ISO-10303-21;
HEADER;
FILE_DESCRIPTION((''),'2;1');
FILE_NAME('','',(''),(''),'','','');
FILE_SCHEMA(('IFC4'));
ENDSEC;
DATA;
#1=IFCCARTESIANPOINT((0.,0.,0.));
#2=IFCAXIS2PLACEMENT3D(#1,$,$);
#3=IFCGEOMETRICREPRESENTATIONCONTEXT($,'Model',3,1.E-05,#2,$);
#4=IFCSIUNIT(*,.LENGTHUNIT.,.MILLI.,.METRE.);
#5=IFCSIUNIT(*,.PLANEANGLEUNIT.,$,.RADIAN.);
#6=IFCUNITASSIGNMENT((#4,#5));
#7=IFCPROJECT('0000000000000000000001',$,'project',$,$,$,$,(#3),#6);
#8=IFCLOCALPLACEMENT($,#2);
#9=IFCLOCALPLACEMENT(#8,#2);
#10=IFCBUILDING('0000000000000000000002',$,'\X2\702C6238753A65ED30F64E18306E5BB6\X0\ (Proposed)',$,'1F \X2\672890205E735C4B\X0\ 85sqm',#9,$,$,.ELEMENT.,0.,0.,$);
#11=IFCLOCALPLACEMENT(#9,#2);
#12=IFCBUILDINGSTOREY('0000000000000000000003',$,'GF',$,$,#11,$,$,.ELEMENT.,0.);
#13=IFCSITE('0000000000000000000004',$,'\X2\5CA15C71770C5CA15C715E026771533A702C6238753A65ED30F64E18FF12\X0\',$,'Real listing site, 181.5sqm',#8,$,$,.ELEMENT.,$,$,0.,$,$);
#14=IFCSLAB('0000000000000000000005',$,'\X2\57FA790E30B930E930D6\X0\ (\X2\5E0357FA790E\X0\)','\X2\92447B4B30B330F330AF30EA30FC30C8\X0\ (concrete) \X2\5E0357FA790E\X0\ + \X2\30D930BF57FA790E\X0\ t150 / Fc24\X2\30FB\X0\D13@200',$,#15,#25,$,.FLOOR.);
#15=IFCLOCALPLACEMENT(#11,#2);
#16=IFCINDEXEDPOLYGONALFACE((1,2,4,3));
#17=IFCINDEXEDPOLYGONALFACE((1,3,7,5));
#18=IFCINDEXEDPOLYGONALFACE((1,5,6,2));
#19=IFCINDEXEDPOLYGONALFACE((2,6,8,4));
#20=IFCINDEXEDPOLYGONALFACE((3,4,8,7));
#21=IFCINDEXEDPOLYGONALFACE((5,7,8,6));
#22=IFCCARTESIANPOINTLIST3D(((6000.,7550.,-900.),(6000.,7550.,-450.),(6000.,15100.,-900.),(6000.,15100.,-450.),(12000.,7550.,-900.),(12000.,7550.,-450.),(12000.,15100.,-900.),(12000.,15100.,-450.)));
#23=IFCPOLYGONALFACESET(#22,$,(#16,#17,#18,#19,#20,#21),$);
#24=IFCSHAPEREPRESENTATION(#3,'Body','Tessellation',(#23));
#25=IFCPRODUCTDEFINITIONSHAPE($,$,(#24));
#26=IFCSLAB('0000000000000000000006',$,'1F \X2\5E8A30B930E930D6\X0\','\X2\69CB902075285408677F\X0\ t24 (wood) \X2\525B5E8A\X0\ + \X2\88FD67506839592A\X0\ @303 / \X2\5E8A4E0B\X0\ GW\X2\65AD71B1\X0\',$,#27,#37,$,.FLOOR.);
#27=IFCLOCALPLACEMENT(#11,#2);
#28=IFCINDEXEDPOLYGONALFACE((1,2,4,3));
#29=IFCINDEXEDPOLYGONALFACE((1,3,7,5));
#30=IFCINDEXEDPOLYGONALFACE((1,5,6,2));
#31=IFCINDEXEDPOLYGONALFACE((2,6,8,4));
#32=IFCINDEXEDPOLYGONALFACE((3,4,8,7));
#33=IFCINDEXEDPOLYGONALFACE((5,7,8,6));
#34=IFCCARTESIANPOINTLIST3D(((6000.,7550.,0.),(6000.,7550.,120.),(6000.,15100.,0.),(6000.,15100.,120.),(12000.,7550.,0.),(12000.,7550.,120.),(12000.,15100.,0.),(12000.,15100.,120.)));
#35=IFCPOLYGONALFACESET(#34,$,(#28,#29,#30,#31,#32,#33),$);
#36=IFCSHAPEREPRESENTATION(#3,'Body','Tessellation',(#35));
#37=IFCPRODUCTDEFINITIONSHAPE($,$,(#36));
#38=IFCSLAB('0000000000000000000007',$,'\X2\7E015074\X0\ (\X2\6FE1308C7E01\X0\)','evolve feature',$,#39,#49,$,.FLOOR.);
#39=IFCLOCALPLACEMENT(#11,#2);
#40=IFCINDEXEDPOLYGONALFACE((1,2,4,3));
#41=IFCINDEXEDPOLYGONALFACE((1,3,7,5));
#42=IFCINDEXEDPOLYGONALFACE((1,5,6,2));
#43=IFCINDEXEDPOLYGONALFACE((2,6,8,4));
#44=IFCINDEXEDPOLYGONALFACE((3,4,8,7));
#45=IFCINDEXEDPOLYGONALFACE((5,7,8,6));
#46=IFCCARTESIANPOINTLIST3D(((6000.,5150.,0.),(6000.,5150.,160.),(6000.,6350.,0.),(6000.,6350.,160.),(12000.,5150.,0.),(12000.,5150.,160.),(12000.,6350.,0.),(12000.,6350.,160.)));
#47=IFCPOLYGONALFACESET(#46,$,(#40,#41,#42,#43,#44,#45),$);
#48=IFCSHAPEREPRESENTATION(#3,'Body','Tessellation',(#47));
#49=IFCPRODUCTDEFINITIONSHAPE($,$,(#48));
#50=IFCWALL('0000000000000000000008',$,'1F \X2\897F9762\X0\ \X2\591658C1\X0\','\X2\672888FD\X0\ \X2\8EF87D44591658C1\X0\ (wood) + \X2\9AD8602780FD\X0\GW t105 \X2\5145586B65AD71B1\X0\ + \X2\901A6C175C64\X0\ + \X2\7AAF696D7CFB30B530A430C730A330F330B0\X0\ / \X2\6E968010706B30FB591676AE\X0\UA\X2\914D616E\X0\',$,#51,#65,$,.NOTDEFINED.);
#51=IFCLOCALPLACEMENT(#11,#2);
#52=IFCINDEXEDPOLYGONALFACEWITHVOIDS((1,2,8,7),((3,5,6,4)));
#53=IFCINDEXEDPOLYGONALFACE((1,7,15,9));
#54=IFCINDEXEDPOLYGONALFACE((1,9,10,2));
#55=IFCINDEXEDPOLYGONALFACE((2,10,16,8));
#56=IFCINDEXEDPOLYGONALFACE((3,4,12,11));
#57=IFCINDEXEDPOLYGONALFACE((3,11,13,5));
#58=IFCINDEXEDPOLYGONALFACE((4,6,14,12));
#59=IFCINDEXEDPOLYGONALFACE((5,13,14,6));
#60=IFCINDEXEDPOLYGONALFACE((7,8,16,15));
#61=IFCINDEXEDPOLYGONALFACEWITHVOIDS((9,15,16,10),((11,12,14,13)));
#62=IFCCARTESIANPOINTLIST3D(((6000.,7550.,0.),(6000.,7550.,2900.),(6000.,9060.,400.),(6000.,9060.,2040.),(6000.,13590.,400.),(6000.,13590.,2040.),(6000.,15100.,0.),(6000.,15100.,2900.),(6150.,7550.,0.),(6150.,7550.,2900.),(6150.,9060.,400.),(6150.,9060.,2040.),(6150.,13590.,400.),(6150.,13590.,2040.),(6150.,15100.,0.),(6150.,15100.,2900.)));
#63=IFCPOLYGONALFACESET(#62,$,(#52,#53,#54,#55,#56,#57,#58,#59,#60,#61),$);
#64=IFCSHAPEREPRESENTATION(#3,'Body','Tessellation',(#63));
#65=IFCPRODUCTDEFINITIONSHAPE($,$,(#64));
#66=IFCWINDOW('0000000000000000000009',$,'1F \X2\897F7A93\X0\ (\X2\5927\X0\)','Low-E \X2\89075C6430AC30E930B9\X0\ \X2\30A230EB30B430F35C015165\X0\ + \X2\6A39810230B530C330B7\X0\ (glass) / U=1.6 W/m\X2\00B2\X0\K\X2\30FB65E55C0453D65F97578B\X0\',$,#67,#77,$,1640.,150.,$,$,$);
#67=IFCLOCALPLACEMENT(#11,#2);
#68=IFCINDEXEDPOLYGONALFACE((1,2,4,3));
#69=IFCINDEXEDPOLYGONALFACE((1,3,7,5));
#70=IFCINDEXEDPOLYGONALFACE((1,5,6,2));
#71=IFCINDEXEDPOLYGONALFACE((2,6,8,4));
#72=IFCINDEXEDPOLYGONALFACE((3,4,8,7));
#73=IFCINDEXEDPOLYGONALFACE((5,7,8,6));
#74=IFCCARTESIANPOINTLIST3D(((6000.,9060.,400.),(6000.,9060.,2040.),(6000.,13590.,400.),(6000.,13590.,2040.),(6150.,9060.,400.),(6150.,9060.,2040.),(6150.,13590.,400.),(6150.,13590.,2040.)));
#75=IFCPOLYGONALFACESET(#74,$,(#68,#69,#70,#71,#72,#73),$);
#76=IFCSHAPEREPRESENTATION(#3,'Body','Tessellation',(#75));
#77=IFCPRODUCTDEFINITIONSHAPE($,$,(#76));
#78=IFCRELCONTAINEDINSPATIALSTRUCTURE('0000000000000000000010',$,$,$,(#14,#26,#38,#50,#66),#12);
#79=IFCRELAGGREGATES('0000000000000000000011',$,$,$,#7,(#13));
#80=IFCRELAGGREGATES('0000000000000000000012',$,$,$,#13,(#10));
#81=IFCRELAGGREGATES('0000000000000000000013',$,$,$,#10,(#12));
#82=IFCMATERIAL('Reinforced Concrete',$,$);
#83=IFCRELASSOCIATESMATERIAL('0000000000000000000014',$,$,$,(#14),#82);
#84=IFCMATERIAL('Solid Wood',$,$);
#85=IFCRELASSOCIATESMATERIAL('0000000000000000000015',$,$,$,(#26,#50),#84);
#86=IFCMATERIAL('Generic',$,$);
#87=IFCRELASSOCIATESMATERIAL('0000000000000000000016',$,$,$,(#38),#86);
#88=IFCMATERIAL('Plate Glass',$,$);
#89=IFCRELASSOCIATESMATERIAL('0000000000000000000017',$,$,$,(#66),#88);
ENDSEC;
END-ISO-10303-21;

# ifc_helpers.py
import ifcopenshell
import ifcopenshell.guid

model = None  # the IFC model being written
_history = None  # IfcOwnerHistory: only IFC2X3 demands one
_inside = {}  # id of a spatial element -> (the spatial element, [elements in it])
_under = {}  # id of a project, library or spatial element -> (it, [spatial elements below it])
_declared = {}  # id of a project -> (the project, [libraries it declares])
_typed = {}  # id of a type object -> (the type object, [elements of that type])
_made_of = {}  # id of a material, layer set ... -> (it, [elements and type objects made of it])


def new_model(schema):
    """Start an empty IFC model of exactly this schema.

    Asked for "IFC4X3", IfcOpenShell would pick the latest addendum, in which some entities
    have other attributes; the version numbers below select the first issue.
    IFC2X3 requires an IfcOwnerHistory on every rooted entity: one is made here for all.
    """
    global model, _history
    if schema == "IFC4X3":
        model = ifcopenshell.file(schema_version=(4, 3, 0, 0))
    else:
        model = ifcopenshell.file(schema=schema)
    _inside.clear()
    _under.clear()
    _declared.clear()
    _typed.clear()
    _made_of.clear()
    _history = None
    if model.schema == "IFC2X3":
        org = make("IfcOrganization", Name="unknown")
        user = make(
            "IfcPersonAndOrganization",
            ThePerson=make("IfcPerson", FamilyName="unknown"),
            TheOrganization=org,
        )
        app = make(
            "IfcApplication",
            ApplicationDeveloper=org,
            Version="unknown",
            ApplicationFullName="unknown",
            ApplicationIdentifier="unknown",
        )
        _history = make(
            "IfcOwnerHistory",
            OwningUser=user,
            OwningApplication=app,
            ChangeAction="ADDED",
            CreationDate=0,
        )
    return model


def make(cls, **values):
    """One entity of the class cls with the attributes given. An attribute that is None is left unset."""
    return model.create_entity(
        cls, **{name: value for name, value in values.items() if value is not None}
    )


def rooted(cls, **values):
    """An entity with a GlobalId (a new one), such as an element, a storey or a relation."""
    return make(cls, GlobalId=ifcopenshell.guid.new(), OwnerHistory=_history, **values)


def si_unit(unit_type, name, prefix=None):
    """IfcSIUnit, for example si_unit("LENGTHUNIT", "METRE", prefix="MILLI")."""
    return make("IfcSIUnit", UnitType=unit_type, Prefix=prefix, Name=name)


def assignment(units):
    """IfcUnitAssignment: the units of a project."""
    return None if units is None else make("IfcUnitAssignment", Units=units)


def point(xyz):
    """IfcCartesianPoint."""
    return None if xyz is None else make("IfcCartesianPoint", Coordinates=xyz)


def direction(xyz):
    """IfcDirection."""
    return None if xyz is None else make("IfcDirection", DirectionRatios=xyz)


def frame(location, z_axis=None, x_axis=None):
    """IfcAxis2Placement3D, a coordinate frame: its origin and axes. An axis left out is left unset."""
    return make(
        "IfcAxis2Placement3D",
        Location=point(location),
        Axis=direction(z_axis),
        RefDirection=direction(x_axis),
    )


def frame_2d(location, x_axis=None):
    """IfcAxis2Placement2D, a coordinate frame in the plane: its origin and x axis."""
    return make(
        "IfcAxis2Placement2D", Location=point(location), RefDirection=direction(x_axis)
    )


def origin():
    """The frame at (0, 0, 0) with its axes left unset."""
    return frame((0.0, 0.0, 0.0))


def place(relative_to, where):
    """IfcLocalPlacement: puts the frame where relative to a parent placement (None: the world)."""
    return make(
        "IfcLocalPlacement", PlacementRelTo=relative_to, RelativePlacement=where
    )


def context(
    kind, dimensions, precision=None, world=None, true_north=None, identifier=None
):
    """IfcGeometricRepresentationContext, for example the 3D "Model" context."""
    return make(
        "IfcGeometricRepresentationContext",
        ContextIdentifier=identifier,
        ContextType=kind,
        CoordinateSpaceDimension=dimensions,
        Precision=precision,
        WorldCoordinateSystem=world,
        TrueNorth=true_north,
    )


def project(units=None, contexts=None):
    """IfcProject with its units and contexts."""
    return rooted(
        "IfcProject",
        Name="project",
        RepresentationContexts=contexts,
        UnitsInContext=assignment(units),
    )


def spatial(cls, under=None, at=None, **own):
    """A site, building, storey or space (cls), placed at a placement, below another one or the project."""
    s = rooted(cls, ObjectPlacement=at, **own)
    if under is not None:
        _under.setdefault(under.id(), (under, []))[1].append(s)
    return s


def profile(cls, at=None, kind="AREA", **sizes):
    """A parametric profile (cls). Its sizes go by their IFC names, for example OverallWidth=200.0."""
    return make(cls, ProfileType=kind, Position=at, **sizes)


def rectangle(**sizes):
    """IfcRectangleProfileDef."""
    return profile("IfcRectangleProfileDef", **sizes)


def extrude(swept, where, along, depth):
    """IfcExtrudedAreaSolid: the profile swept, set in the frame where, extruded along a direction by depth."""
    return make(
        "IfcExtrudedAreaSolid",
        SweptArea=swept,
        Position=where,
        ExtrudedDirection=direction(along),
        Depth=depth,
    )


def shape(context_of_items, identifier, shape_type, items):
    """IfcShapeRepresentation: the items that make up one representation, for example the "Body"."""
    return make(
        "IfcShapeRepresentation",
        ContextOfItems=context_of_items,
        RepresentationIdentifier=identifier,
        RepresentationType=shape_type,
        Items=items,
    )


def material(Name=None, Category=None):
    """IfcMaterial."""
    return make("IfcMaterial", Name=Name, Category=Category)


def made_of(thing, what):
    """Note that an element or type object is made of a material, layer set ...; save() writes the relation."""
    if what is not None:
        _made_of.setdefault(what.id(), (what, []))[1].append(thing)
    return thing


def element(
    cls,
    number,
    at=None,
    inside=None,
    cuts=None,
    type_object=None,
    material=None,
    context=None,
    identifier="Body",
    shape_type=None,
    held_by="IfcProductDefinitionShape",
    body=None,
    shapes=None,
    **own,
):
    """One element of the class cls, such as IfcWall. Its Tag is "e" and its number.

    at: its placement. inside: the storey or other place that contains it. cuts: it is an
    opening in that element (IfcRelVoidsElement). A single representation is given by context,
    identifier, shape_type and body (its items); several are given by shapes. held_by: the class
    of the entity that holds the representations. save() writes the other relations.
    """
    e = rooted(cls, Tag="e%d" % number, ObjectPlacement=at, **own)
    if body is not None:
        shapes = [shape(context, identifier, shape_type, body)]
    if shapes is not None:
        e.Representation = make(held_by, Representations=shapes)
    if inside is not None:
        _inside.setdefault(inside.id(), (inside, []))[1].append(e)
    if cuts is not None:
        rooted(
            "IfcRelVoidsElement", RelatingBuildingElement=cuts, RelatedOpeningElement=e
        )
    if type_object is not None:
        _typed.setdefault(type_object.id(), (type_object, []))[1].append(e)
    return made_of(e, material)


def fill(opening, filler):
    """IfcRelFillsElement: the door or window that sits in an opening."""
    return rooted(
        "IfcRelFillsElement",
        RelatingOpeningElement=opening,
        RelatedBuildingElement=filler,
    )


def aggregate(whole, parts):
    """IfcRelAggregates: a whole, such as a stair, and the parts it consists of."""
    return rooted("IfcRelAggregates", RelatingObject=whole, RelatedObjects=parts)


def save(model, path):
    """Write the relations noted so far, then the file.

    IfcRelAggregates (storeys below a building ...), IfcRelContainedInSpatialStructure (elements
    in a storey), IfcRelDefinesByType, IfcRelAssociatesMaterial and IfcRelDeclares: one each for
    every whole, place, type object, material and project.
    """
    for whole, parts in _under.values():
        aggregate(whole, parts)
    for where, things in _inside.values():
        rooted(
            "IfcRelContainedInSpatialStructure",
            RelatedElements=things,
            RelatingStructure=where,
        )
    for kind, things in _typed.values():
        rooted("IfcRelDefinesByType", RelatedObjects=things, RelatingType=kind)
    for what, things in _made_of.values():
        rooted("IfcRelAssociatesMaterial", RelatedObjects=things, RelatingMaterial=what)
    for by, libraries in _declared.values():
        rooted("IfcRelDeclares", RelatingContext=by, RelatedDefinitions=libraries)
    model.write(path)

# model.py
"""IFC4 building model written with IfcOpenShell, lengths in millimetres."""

from ifc_helpers import new_model, si_unit, frame, frame_2d, origin, place, context, project, spatial, rectangle, extrude, material, element, fill, save


model = new_model("IFC4")

# Units and contexts
model_context = context("Model", 3, precision=1e-05, world=origin())
ifc_project = project(units=[si_unit("LENGTHUNIT", "METRE", prefix="MILLI"), si_unit("PLANEANGLEUNIT", "RADIAN")], contexts=[model_context])

# Site, building, storey
site_placement = place(None, origin())
site = spatial("IfcSite", under=ifc_project, at=site_placement, Name="岡山県岡山市東区瀬戸町旭ヶ丘２", ObjectType="Real listing site, 181.5sqm", CompositionType="ELEMENT", RefElevation=0.0)
building_placement = place(site_placement, origin())
building = spatial("IfcBuilding", under=site, at=building_placement, Name="瀬戸町旭ヶ丘の家 (Proposed)", ObjectType="1F 木造平屋 85sqm", CompositionType="ELEMENT", ElevationOfRefHeight=0.0, ElevationOfTerrain=0.0)
storey_placement = place(building_placement, origin())
storey = spatial("IfcBuildingStorey", under=building, at=storey_placement, Name="GF", CompositionType="ELEMENT", Elevation=0.0)

# Slabs
ifc_material_1 = material(Name="Reinforced Concrete")
slab_1_placement = place(storey_placement, frame((3000.0, 3775.0, -450.0)))
element("IfcSlab", 1, at=slab_1_placement, inside=storey, material=ifc_material_1, Name="基礎スラブ (布基礎)", Description="鉄筋コンクリート (concrete) 布基礎 + ベタ基礎 t150 / Fc24・D13@200", PredefinedType="FLOOR", context=model_context, shape_type="SweptSolid", body=[
    extrude(rectangle(XDim=6000.0, YDim=7550.0, at=frame_2d((3000.0, 3775.0))), frame((3000.0, 3775.0, -450.0)), (0.0, 0.0, 1.0), 450.0),
])
ifc_material_2 = material(Name="Solid Wood")
slab_2_placement = place(storey_placement, frame((3000.0, 3775.0, 0.0)))
element("IfcSlab", 2, at=slab_2_placement, inside=storey, material=ifc_material_2, Name="1F 床スラブ", Description="構造用合板 t24 (wood) 剛床 + 製材根太 @303 / 床下 GW断熱", PredefinedType="FLOOR", context=model_context, shape_type="SweptSolid", body=[
    extrude(rectangle(XDim=6000.0, YDim=7550.0, at=frame_2d((3000.0, 3775.0))), frame((3000.0, 3775.0, 0.0)), (0.0, 0.0, 1.0), 120.0),
])
ifc_material_3 = material(Name="Generic")
slab_3_placement = place(storey_placement, frame((3000.0, 2575.0, 0.0)))
element("IfcSlab", 3, at=slab_3_placement, inside=storey, material=ifc_material_3, Name="縁側 (濡れ縁)", Description="evolve feature", PredefinedType="FLOOR", context=model_context, shape_type="SweptSolid", body=[
    extrude(rectangle(XDim=6000.0, YDim=1200.0, at=frame_2d((3000.0, 600.0))), frame((3000.0, 2575.0, 0.0)), (0.0, 0.0, 1.0), 160.0),
])

# Shared definitions
ifc_material_4 = material(Name="Plate Glass")

# Wall, opening, window
wall_1_placement = place(storey_placement, frame((3000.0, 3775.0, 0.0)))
wall_1 = element("IfcWall", 4, at=wall_1_placement, inside=storey, material=ifc_material_2, Name="1F 西面 外壁", Description="木製 軸組外壁 (wood) + 高性能GW t105 充填断熱 + 通気層 + 窯業系サイディング / 準耐火・外皮UA配慮", PredefinedType="NOTDEFINED", context=model_context, shape_type="SweptSolid", body=[
    extrude(rectangle(XDim=150.0, YDim=7550.0, at=frame_2d((75.0, 3775.0))), frame((3000.0, 3775.0, 0.0)), (0.0, 0.0, 1.0), 2900.0),
])
opening_1_placement = place(storey_placement, frame((3000.0, 4530.0, 200.0)))
opening_1 = element("IfcOpeningElement", 5, at=opening_1_placement, cuts=wall_1, PredefinedType="NOTDEFINED", context=model_context, shape_type="SweptSolid", body=[
    extrude(rectangle(XDim=150.0, YDim=4530.0, at=frame_2d((75.0, 2265.0))), frame((3000.0, 4530.0, 200.0)), (0.0, 0.0, 1.0), 1640.0),
])
window_1_placement = place(storey_placement, frame((3000.0, 4530.0, 200.0)))
window_1 = element("IfcWindow", 6, at=window_1_placement, inside=storey, material=ifc_material_4, Name="1F 西窓 (大)", Description="Low-E 複層ガラス アルゴン封入 + 樹脂サッシ (glass) / U=1.6 W/m²K・日射取得型", OverallHeight=1640.0, OverallWidth=150.0, context=model_context, shape_type="SweptSolid", body=[
    extrude(rectangle(XDim=150.0, YDim=4530.0, at=frame_2d((75.0, 2265.0))), frame((3000.0, 4530.0, 200.0)), (0.0, 0.0, 1.0), 1640.0),
])
fill(opening_1, window_1)

save(model, "model.ifc")
